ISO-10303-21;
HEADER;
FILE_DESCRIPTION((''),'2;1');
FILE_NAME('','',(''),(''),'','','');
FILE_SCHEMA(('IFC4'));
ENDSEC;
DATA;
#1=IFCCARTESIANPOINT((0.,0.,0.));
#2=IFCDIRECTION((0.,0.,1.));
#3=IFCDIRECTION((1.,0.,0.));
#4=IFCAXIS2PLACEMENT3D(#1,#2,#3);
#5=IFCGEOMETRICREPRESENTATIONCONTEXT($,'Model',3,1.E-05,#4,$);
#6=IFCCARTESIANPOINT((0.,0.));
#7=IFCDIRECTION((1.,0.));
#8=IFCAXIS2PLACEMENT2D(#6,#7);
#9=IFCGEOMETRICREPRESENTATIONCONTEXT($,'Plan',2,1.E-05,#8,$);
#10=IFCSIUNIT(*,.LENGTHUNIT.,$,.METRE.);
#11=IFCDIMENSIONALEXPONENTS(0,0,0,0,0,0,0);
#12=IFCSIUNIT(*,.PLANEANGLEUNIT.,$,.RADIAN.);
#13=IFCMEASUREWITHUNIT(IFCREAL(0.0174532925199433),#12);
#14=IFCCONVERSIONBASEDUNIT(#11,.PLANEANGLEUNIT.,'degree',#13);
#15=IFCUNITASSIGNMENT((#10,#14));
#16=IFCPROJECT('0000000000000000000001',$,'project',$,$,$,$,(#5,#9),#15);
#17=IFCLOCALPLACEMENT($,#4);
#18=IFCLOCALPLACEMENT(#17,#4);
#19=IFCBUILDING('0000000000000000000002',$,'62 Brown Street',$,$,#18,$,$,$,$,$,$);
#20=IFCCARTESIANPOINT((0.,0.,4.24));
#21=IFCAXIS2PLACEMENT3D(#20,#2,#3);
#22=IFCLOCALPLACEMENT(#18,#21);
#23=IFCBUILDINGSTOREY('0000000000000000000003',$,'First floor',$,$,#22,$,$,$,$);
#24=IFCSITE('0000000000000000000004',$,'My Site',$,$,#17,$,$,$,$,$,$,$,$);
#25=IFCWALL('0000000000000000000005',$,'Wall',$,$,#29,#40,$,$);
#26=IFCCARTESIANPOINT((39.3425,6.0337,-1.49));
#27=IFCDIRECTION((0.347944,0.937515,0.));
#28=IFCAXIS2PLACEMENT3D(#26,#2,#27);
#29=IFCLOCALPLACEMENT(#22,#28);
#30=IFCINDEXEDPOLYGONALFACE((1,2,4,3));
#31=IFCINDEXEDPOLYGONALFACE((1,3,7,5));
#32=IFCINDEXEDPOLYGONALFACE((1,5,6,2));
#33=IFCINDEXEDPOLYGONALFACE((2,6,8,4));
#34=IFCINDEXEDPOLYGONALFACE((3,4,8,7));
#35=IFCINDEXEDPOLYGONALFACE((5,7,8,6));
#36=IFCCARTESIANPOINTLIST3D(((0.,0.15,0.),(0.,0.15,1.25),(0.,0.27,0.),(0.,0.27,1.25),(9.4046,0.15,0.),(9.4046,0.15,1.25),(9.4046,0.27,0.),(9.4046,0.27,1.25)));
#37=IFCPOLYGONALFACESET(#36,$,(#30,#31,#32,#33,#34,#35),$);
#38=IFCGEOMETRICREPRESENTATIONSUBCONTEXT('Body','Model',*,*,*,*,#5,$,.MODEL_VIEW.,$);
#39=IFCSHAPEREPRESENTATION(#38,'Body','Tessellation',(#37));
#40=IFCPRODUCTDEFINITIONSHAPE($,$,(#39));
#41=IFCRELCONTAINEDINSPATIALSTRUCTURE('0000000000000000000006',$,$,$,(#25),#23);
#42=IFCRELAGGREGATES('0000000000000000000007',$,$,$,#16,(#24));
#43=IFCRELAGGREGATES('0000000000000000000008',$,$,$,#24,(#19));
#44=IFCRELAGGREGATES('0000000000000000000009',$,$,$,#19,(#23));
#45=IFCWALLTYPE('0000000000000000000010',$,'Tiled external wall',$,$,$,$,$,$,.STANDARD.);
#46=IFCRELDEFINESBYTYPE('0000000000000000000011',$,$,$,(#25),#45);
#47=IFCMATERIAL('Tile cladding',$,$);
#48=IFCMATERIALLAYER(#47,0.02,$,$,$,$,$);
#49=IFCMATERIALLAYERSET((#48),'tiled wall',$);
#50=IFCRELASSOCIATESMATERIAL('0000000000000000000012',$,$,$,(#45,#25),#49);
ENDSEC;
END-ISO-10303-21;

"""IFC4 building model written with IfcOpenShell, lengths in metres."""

from ifc_helpers import new_model, entity, si_unit, converted_unit, frame, origin_with_axes, origin_2d_with_axis, place, context, subcontext, project, spatial, indexed_curve, outline, extrude, material, layer, layer_set, layer_usage, type_object, element, save


model = new_model("IFC4")

# Units and contexts
model_context = context("Model", 3, precision=1e-05, world=origin_with_axes())
plan_context = context("Plan", 2, precision=1e-05, world=origin_2d_with_axis())
body_context_1 = subcontext(model_context, "Body", "Model", "MODEL_VIEW")
ifc_project = project(units=[si_unit("LENGTHUNIT", "METRE"), converted_unit("PLANEANGLEUNIT", "degree", entity("IfcReal", 0.0174532925199433), si_unit("PLANEANGLEUNIT", "RADIAN"), dimensions=[0, 0, 0, 0, 0, 0, 0])], contexts=[model_context, plan_context])

# Site, building, storey
site_placement = place(None, origin_with_axes())
site = spatial("IfcSite", under=ifc_project, at=site_placement, Name="My Site")
building_placement = place(site_placement, origin_with_axes())
building = spatial("IfcBuilding", under=site, at=building_placement, Name="62 Brown Street")
storey_placement = place(building_placement, frame((0.0, 0.0, 4.24), z_axis=(0.0, 0.0, 1.0), x_axis=(1.0, 0.0, 0.0)))
storey = spatial("IfcBuildingStorey", under=building, at=storey_placement, Name="First floor")

# Wall
ifc_material_1 = material(Name="Tile cladding")
ifc_layer_1 = layer(ifc_material_1, 0.02)
ifc_layer_set_1 = layer_set([ifc_layer_1], Name="tiled wall")
ifc_layer_usage_1 = layer_usage(ifc_layer_set_1, "AXIS2", "POSITIVE", 0.15)
wall_type_1 = type_object("IfcWallType", Name="Tiled external wall", PredefinedType="STANDARD", material=ifc_layer_set_1)
wall_1_placement = place(storey_placement, frame((39.3425, 6.0337, -1.49), z_axis=(0.0, 0.0, 1.0), x_axis=(0.347944, 0.937515, 0.0)))
element("IfcWall", 1, at=wall_1_placement, inside=storey, type_object=wall_type_1, material=ifc_layer_usage_1, Name="Wall", context=body_context_1, shape_type="SweptSolid", body=[
    extrude(outline(indexed_curve([(0.0, 0.0), (0.0, 0.12), (9.4046, 0.12), (9.4046, 0.0), (0.0, 0.0)], self_intersect=False)), frame((0.0, 0.15, 0.0), z_axis=(0.0, 0.0, 1.0), x_axis=(1.0, 0.0, 0.0)), (0.0, 0.0, 1.0), 1.25),
])

save(model, "model.ifc")
